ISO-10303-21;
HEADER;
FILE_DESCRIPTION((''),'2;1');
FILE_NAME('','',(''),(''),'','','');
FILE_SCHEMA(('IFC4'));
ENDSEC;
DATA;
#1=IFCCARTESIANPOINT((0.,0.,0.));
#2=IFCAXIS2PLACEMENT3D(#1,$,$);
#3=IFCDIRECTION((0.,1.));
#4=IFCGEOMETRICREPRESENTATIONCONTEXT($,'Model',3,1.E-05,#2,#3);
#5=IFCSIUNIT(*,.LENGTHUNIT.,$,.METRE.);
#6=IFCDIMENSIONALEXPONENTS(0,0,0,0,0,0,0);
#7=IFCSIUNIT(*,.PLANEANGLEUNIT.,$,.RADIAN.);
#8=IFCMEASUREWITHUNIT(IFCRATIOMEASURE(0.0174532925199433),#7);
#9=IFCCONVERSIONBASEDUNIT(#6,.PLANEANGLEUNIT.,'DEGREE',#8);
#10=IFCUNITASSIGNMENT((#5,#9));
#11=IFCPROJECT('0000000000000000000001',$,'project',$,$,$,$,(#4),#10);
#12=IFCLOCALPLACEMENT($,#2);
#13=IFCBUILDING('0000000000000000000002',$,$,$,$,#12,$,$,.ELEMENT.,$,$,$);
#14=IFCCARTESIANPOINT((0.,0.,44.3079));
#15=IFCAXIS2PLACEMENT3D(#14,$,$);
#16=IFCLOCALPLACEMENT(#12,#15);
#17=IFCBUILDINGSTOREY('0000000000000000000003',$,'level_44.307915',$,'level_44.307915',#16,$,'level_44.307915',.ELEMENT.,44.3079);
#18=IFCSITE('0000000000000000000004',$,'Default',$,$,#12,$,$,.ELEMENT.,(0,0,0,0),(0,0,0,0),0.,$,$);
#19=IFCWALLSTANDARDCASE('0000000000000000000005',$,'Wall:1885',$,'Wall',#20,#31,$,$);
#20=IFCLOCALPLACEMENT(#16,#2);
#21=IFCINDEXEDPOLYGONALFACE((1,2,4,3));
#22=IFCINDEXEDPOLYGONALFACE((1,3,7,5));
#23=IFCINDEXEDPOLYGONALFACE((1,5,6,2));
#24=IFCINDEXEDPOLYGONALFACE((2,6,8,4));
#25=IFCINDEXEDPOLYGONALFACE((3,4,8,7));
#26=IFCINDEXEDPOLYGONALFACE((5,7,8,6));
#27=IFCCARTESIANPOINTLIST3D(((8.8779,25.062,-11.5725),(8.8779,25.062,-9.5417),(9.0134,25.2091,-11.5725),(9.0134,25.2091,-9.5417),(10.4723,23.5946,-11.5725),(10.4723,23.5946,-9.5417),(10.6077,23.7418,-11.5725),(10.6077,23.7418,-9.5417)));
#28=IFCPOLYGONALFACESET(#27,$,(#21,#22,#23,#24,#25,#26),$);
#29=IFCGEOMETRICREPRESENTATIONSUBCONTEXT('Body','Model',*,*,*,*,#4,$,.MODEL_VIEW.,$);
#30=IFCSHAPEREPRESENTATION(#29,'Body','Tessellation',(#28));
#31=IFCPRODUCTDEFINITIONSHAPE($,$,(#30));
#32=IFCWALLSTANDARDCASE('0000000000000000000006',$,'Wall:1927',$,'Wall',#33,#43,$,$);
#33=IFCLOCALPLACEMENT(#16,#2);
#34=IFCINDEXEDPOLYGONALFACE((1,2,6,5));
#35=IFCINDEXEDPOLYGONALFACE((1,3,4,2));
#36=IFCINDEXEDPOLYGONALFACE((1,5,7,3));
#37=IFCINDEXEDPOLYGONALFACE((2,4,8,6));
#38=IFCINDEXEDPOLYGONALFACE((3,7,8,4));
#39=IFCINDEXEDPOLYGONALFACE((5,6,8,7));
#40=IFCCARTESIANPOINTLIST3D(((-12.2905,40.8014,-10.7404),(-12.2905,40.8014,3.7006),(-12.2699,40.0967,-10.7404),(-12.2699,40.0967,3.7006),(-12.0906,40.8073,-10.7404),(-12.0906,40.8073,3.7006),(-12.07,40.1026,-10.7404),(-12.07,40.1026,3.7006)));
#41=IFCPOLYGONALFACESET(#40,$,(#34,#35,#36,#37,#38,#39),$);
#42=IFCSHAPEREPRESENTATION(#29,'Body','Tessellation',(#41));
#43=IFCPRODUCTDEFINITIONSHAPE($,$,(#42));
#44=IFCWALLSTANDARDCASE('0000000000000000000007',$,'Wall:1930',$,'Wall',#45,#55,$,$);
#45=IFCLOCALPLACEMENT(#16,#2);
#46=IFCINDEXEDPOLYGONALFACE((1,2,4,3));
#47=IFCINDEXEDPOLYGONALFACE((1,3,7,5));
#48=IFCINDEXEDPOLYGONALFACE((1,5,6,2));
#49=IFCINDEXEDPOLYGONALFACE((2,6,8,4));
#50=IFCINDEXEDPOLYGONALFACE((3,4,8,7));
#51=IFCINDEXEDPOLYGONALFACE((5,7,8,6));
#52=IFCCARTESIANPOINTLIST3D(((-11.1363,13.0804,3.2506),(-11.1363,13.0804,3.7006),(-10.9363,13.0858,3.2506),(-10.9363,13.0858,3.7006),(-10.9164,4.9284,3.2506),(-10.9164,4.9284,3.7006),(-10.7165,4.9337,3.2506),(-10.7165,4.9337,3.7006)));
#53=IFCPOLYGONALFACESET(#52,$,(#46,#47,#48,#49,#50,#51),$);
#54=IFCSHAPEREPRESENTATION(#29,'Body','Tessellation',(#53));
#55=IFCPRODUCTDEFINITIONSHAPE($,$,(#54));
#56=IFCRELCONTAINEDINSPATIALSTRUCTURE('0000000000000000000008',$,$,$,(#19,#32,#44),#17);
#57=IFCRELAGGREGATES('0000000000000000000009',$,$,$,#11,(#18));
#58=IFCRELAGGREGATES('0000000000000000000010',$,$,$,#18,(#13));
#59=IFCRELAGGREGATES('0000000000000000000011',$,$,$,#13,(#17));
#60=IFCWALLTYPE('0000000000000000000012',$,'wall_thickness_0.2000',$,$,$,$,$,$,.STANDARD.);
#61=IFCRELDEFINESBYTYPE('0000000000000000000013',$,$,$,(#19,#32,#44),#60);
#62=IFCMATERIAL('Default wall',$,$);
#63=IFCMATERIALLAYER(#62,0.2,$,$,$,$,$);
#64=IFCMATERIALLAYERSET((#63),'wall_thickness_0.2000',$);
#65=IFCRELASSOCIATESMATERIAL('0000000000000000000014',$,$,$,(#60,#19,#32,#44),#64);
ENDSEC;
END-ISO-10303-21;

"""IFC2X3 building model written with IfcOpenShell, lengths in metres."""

from ifc_helpers import new_model, entity, si_unit, converted_unit, direction, frame, origin, place, context, subcontext, project, spatial, polyline, outline, extrude, material, layer, layer_set, layer_usage, type_object, element, save


model = new_model("IFC2X3")

# Units and contexts
model_context = context("Model", 3, precision=1e-05, world=origin(), true_north=direction((0.0, 1.0)))
body_context = subcontext(model_context, "Body", "Model", "MODEL_VIEW")
ifc_project = project(units=[si_unit("LENGTHUNIT", "METRE"), converted_unit("PLANEANGLEUNIT", "DEGREE", entity("IfcRatioMeasure", 0.0174532925199433), si_unit("PLANEANGLEUNIT", "RADIAN"), dimensions=[0, 0, 0, 0, 0, 0, 0])], contexts=[model_context])

# Site, building, storey
placement_1 = place(None, origin())
site = spatial("IfcSite", under=ifc_project, at=placement_1, Name="Default", CompositionType="ELEMENT", RefLatitude=(0, 0, 0, 0), RefLongitude=(0, 0, 0, 0), RefElevation=0.0)
building = spatial("IfcBuilding", under=site, at=placement_1, CompositionType="ELEMENT")
storey_placement = place(placement_1, frame((0.0, 0.0, 44.3079)))
storey = spatial("IfcBuildingStorey", under=building, at=storey_placement, Name="level_44.307915", ObjectType="level_44.307915", LongName="level_44.307915", CompositionType="ELEMENT", Elevation=44.3079)

# Shared definitions
ifc_material_1 = material(Name="Default wall")
ifc_layer = layer(ifc_material_1, 0.2)
ifc_layer_set = layer_set([ifc_layer], Name="wall_thickness_0.2000")
ifc_layer_usage = layer_usage(ifc_layer_set, "AXIS2", "POSITIVE", -0.1)
wall_type = type_object("IfcWallType", Name="wall_thickness_0.2000", PredefinedType="STANDARD", material=ifc_layer_set)

# Walls
placement_2 = place(placement_1, frame((0.0, 0.0, 32.7354)))
wall_1_placement = place(placement_2, frame((10.54, 23.6682, 0.0), z_axis=(0.0, 0.0, 1.0), x_axis=(-0.7358, 0.677199, 0.0)))
element("IfcWallStandardCase", 1, at=wall_1_placement, inside=storey, type_object=wall_type, material=ifc_layer_usage, Name="Wall:1885", ObjectType="Wall", context=body_context, shape_type="SweptSolid", body=[
    extrude(outline(polyline([(2.1668, -0.1), (2.1668, 0.1), (0.0, 0.1), (0.0, -0.1), (2.1668, -0.1)])), origin(), (0.0, 0.0, 1.0), 2.0308),
])
placement_3 = place(placement_1, frame((0.0, 0.0, 33.5675)))
wall_2_placement = place(placement_3, frame((-12.1699, 40.0996, 0.0), z_axis=(0.0, 0.0, 1.0), x_axis=(-0.029262, 0.999572, 0.0)))
element("IfcWallStandardCase", 2, at=wall_2_placement, inside=storey, type_object=wall_type, material=ifc_layer_usage, Name="Wall:1927", ObjectType="Wall", context=body_context, shape_type="SweptSolid", body=[
    extrude(outline(polyline([(0.705, -0.1), (0.705, 0.1), (0.0, 0.1), (0.0, -0.1), (0.705, -0.1)])), origin(), (0.0, 0.0, 1.0), 14.441),
])
placement_4 = place(placement_1, frame((0.0, 0.0, 47.5585)))
wall_3_placement = place(placement_4, frame((-11.0363, 13.0831, 0.0), z_axis=(0.0, 0.0, 1.0), x_axis=(0.026962, -0.999636, 0.0)))
element("IfcWallStandardCase", 3, at=wall_3_placement, inside=storey, type_object=wall_type, material=ifc_layer_usage, Name="Wall:1930", ObjectType="Wall", context=body_context, shape_type="SweptSolid", body=[
    extrude(outline(polyline([(8.155, -0.1), (8.155, 0.1), (0.0, 0.1), (0.0, -0.1), (8.155, -0.1)])), origin(), (0.0, 0.0, 1.0), 0.45),
])

save(model, "model.ifc")
